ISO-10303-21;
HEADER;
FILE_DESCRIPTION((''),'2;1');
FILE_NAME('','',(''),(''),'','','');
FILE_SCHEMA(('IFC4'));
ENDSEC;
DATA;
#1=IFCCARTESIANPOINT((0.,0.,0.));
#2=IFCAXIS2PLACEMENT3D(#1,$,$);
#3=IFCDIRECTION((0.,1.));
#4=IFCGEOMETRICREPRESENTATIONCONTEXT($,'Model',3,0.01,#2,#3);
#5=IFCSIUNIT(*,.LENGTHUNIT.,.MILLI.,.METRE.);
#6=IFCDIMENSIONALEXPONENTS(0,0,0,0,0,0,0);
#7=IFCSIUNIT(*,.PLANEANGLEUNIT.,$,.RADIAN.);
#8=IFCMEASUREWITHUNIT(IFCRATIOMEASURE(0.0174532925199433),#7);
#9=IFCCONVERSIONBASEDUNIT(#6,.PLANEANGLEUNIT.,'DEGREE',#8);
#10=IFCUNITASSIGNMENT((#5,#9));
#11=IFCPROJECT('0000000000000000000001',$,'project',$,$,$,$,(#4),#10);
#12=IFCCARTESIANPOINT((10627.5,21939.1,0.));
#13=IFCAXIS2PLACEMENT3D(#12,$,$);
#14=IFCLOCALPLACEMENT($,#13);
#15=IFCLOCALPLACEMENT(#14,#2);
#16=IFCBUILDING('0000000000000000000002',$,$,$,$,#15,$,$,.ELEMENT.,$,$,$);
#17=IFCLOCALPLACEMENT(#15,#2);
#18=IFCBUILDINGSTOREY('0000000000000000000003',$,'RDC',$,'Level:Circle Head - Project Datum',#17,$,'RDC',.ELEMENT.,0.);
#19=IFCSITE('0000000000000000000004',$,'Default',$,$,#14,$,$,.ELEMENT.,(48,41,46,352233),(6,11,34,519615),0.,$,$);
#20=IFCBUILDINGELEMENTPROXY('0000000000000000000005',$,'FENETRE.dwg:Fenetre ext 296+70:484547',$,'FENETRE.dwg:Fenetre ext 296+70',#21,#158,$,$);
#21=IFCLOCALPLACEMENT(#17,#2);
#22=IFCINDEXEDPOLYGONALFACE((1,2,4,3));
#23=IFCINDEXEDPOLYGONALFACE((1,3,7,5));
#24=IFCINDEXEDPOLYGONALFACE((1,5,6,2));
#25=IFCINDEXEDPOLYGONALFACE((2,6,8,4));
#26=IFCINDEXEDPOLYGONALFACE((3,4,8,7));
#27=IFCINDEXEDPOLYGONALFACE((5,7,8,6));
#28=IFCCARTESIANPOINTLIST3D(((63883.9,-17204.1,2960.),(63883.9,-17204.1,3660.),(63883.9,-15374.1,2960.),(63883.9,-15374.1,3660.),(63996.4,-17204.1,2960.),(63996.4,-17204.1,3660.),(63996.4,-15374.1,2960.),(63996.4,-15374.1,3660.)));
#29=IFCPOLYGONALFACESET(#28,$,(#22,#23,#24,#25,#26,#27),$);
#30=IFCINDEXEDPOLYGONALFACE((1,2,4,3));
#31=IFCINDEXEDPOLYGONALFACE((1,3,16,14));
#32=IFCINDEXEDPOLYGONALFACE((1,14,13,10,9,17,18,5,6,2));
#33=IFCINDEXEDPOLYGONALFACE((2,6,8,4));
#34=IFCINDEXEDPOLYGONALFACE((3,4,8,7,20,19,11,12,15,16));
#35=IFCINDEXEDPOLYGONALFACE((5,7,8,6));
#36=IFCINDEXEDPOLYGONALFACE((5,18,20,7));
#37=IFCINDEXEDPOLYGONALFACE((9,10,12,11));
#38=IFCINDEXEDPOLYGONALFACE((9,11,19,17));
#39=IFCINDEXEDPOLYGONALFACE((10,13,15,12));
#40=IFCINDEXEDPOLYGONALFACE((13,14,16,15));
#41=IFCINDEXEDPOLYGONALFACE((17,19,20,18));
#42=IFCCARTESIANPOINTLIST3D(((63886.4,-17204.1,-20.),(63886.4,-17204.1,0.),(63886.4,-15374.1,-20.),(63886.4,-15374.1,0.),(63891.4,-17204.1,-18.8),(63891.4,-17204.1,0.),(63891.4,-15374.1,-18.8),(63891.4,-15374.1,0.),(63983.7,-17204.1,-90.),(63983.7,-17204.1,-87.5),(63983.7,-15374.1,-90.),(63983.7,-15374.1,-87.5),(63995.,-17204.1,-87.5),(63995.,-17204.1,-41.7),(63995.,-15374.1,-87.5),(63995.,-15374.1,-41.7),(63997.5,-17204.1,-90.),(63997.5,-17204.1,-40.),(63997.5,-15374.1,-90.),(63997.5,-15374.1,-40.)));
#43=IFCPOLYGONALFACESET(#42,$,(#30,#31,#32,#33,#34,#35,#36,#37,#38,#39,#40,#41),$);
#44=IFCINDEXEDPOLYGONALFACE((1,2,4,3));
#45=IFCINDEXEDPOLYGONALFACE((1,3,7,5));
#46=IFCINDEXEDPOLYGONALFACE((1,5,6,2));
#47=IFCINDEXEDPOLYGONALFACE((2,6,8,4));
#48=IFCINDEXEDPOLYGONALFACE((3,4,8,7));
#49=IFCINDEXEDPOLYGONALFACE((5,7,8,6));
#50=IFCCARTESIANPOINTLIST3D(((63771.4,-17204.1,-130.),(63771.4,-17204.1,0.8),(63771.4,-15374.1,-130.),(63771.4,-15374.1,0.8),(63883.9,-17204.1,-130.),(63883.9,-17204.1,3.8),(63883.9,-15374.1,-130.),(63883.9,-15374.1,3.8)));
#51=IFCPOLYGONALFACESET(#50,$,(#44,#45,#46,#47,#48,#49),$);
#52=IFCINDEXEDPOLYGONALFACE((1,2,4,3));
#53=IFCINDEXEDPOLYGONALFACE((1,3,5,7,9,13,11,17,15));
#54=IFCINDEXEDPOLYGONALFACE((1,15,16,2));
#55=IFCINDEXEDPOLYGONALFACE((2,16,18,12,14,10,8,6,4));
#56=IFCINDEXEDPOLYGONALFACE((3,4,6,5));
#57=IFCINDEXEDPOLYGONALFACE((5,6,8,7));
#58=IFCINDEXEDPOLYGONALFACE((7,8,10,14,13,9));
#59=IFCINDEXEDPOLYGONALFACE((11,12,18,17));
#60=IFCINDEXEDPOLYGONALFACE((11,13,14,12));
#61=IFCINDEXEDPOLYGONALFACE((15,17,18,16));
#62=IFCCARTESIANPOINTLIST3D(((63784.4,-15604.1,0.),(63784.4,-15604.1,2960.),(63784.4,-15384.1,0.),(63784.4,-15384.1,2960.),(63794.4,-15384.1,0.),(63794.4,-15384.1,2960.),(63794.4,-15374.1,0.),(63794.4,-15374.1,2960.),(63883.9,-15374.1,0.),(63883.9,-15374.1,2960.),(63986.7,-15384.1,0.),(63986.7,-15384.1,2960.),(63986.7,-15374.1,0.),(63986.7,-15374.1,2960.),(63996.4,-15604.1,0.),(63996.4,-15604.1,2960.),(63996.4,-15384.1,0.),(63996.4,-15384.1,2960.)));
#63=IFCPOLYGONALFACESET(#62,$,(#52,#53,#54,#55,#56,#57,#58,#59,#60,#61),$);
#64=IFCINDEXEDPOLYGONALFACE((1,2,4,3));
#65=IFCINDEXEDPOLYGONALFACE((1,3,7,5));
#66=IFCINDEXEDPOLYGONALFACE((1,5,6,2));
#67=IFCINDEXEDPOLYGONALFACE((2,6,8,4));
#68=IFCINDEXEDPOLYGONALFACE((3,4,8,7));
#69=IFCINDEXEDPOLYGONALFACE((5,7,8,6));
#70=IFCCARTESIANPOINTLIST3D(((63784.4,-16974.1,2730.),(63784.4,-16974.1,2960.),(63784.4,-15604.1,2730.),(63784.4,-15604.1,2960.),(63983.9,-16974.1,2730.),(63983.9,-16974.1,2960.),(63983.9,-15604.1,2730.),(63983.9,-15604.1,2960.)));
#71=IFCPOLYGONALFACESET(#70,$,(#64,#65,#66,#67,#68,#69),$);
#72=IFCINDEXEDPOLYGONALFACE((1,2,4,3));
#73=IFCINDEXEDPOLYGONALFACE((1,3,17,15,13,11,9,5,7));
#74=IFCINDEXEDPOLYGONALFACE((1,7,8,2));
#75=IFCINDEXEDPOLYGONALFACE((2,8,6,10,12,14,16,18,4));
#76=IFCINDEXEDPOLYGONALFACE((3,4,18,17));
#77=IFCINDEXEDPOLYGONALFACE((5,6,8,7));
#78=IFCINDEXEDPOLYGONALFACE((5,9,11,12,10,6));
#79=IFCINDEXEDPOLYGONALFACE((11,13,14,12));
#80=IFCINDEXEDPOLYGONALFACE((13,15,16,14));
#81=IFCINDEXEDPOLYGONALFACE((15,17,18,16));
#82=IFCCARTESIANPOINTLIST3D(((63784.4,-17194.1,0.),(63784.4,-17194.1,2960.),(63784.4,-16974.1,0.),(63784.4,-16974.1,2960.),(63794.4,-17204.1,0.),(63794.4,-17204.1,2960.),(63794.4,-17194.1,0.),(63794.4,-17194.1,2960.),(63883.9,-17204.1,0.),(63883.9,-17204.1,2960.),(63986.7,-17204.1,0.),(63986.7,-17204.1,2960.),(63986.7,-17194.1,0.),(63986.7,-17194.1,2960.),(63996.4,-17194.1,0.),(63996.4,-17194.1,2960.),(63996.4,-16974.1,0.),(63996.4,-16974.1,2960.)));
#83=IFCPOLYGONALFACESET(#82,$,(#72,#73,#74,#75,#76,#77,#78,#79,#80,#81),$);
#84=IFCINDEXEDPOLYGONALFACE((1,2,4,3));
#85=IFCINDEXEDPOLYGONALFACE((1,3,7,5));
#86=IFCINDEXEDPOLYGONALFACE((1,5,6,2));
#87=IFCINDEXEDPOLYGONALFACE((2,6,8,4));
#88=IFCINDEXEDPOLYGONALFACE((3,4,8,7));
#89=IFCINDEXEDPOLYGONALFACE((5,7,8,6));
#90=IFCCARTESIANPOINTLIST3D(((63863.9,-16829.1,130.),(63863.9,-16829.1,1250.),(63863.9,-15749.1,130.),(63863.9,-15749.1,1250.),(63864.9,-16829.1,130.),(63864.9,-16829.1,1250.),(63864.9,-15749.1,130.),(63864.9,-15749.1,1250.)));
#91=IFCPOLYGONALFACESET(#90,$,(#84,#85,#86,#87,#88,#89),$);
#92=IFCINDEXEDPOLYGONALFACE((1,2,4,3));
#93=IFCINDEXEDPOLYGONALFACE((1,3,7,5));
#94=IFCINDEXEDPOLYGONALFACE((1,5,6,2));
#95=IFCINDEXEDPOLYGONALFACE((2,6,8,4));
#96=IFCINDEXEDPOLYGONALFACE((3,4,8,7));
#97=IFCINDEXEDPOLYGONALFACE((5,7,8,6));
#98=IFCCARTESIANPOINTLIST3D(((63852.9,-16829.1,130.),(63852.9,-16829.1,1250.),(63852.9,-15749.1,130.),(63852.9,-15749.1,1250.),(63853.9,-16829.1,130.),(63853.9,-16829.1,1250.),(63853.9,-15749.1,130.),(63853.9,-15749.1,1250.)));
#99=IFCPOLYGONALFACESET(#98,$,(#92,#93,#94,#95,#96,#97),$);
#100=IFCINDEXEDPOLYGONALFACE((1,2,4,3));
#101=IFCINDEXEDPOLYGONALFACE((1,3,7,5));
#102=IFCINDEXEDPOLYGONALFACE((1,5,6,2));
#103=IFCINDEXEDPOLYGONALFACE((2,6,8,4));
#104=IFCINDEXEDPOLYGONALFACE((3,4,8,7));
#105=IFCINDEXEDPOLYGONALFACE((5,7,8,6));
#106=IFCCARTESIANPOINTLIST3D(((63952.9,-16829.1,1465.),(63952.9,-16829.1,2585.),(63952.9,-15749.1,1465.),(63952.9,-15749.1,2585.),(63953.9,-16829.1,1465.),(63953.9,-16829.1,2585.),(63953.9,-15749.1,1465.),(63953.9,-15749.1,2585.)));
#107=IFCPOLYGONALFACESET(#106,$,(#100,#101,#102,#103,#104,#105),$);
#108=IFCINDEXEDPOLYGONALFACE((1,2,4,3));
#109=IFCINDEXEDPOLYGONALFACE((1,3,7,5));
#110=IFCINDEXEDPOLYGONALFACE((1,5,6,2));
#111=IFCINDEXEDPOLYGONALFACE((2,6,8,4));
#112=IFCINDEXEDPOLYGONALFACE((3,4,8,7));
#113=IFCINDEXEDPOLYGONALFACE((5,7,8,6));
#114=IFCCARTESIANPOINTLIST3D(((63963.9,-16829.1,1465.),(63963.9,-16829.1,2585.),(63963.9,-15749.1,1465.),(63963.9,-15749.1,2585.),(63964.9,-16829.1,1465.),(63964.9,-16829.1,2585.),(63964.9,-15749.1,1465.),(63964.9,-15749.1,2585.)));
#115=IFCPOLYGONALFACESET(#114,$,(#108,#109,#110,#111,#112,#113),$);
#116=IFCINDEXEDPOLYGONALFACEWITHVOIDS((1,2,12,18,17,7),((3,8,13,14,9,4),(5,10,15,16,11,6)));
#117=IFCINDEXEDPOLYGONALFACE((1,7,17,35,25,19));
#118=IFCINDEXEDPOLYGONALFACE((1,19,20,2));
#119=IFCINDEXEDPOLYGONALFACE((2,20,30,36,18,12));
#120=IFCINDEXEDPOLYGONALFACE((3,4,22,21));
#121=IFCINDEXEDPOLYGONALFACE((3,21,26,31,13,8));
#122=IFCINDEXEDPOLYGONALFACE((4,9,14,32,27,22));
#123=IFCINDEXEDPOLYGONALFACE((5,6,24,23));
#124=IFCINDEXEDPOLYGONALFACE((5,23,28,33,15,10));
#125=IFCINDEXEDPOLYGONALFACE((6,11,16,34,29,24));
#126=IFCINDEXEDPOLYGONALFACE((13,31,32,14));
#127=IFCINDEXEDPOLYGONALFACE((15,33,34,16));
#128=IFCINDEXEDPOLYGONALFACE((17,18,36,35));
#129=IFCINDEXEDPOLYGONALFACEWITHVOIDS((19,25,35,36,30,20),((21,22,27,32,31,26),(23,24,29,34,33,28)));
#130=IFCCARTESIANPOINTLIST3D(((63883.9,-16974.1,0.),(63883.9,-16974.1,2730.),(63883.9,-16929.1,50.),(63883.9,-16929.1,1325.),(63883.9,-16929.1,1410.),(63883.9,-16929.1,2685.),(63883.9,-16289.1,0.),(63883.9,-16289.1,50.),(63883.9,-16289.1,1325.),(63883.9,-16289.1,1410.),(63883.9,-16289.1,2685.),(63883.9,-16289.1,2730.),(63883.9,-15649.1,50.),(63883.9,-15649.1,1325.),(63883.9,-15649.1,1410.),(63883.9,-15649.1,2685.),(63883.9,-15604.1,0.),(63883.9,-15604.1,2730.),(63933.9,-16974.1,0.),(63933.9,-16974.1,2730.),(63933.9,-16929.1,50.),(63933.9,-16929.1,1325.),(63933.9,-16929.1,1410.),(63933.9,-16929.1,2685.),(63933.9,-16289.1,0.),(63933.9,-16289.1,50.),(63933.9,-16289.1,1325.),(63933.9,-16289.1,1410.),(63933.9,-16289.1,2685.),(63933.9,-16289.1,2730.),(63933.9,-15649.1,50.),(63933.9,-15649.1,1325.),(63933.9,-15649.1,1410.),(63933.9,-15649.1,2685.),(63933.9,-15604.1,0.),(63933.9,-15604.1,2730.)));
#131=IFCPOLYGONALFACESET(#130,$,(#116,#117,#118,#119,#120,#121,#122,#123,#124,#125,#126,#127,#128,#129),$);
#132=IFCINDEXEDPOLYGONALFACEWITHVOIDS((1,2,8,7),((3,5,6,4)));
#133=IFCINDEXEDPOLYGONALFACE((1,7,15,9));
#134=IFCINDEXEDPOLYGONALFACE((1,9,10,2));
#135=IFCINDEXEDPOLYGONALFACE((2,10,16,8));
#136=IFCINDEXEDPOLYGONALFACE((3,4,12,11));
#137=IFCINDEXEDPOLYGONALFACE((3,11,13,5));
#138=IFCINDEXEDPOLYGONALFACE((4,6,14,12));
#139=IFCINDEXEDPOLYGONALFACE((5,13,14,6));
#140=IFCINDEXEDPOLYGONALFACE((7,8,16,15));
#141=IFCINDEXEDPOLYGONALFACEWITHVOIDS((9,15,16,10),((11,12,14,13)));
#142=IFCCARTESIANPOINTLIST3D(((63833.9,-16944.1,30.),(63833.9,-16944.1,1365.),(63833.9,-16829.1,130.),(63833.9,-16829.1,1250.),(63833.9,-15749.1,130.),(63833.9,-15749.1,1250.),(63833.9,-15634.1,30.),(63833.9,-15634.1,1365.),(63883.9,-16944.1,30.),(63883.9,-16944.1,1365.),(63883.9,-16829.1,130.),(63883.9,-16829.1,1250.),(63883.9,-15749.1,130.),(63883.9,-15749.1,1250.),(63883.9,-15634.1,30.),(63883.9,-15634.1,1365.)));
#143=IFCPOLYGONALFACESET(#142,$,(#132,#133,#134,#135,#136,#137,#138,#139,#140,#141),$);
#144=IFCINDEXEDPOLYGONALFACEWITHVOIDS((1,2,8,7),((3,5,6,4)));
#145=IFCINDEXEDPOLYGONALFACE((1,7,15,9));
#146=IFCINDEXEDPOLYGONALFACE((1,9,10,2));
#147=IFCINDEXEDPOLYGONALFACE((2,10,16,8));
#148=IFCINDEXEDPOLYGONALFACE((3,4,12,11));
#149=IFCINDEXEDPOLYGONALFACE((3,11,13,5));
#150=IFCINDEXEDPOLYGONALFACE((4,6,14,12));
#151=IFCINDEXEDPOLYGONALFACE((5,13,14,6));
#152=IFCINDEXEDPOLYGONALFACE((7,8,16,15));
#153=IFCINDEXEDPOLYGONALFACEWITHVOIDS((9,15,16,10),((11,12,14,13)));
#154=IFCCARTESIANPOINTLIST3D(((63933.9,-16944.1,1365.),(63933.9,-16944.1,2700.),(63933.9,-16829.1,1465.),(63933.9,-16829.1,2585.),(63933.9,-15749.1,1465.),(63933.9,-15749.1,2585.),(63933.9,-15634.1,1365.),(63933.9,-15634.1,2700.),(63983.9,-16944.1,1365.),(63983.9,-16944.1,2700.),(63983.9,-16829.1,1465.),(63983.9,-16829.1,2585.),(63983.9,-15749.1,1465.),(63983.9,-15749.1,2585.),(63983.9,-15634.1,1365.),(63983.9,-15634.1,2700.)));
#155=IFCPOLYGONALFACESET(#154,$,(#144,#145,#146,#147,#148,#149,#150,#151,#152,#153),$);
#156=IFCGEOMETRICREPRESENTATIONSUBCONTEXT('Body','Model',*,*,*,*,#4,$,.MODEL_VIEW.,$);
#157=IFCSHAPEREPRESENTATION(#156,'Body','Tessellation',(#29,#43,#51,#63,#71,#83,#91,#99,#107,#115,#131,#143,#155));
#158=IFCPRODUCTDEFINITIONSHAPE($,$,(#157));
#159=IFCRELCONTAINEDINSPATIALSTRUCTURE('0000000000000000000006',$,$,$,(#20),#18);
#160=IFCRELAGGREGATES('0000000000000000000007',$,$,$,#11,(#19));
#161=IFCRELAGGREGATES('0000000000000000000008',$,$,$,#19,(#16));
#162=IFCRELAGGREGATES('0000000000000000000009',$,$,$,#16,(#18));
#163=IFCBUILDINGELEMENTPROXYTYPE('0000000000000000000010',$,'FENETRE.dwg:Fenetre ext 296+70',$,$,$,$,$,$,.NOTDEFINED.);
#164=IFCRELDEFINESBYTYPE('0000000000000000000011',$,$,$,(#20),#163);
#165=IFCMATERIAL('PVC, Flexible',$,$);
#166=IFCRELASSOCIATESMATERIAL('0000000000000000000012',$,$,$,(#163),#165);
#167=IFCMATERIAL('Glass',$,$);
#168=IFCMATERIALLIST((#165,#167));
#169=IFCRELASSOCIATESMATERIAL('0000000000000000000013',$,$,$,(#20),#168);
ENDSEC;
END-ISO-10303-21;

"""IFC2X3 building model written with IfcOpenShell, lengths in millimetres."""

from ifc_helpers import new_model, entity, si_unit, converted_unit, direction, frame, frame_2d, origin, origin_2d_with_axis, place, context, subcontext, project, spatial, polyline, rectangle, outline, extrude, source, transform, mapped, material, material_list, type_object, type_shapes, element, save


model = new_model("IFC2X3")

# Units and contexts
model_context = context("Model", 3, precision=0.01, world=origin(), true_north=direction((0.0, 1.0)))
body_context = subcontext(model_context, "Body", "Model", "MODEL_VIEW")
ifc_project = project(units=[si_unit("LENGTHUNIT", "METRE", prefix="MILLI"), converted_unit("PLANEANGLEUNIT", "DEGREE", entity("IfcRatioMeasure", 0.0174532925199433), si_unit("PLANEANGLEUNIT", "RADIAN"), dimensions=[0, 0, 0, 0, 0, 0, 0])], contexts=[model_context])

# Site, building, storey
site_placement = place(None, frame((10627.5, 21939.1, 0.0)))
site = spatial("IfcSite", under=ifc_project, at=site_placement, Name="Default", CompositionType="ELEMENT", RefLatitude=(48, 41, 46, 352233), RefLongitude=(6, 11, 34, 519615), RefElevation=0.0)
building_placement = place(site_placement, origin())
building = spatial("IfcBuilding", under=site, at=building_placement, CompositionType="ELEMENT")
storey_placement = place(building_placement, origin())
storey = spatial("IfcBuildingStorey", under=building, at=storey_placement, Name="RDC", ObjectType="Level:Circle Head - Project Datum", LongName="RDC", CompositionType="ELEMENT", Elevation=0.0)

# Building element proxy
ifc_material_1 = material(Name="PVC, Flexible")
ifc_material_2 = material(Name="Glass")
building_element_proxy_type_1 = type_object("IfcBuildingElementProxyType", Name="FENETRE.dwg:Fenetre ext 296+70", PredefinedType="NOTDEFINED", material=ifc_material_1)
shared_shape_1 = source(origin(), body_context, "Body", "SweptSolid", [
    extrude(rectangle(XDim=112.5, YDim=1830.0, at=origin_2d_with_axis()), frame((-10.4, -56.3, 2960.0), z_axis=(0.0, 0.0, 1.0), x_axis=(0.0, 1.0, 0.0)), (0.0, 0.0, 1.0), 700.0),
    extrude(outline(polyline([(27.5, -64.4), (47.5, -64.4), (47.5, -59.4), (28.8, -59.4), (7.5, 46.7), (-42.5, 46.7), (-42.5, 32.9), (-40.0, 32.9), (-40.0, 44.2), (5.8, 44.2), (27.5, -64.4)])), frame((-925.4, -66.9, -47.5), z_axis=(1.0, 0.0, 0.0), x_axis=(0.0, 0.0, 1.0)), (0.0, 0.0, 1.0), 1830.0),
    extrude(outline(polyline([(-54.5, -66.1), (58.0, -66.1), (54.5, 67.6), (-58.0, 64.6), (-54.5, -66.1)])), frame((-925.4, 56.3, -63.8), z_axis=(1.0, 0.0, 0.0), x_axis=(0.0, -0.999645, 0.02665)), (0.0, 0.0, 1.0), 1830.0),
    extrude(outline(polyline([(-97.0, -55.6), (5.9, -55.6), (95.4, -55.6), (95.4, -45.6), (105.4, -45.6), (105.4, 174.4), (-106.6, 174.4), (-106.6, -45.6), (-97.0, -45.6), (-97.0, -55.6)])), frame((849.0, -5.9, 0.0), z_axis=(0.0, 0.0, 1.0), x_axis=(0.0, 1.0, 0.0)), (0.0, 0.0, 1.0), 2960.0),
    extrude(rectangle(XDim=1370.0, YDim=199.5, at=origin_2d_with_axis()), frame((-10.4, -0.3, 2730.0), z_axis=(0.0, 0.0, 1.0), x_axis=(-1.0, 0.0, 0.0)), (0.0, 0.0, 1.0), 230.0),
    extrude(outline(polyline([(-55.6, 97.0), (-55.6, -5.9), (-55.6, -95.4), (-45.6, -95.4), (-45.6, -105.4), (174.4, -105.4), (174.4, 106.6), (-45.6, 106.6), (-45.6, 97.0), (-55.6, 97.0)])), frame((-869.9, -5.9, 0.0), z_axis=(0.0, 0.0, -1.0), x_axis=(1.0, 0.0, 0.0)), (0.0, 0.0, -1.0), 2960.0),
    extrude(rectangle(XDim=1080.0, YDim=1.0, at=origin_2d_with_axis()), frame((-10.4, 19.5, 130.0), z_axis=(0.0, 0.0, 1.0), x_axis=(-1.0, 0.0, 0.0)), (0.0, 0.0, 1.0), 1120.0),
    extrude(rectangle(XDim=1080.0, YDim=1.0, at=origin_2d_with_axis()), frame((-10.4, 30.5, 130.0), z_axis=(0.0, 0.0, 1.0), x_axis=(-1.0, 0.0, 0.0)), (0.0, 0.0, 1.0), 1120.0),
    extrude(rectangle(XDim=1080.0, YDim=1.0, at=frame_2d((0.0, 0.0), x_axis=(1.0, 0.0))), frame((-10.4, -69.5, 1465.0), z_axis=(0.0, 0.0, 1.0), x_axis=(-1.0, 0.0, 0.0)), (0.0, 0.0, 1.0), 1120.0),
    extrude(rectangle(XDim=1080.0, YDim=1.0, at=frame_2d((0.0, 0.0), x_axis=(1.0, 0.0))), frame((-10.4, -80.5, 1465.0), z_axis=(0.0, 0.0, 1.0), x_axis=(-1.0, 0.0, 0.0)), (0.0, 0.0, 1.0), 1120.0),
    extrude(outline(polyline([(-685.0, -1365.0), (0.0, -1365.0), (685.0, -1365.0), (685.0, 1365.0), (0.0, 1365.0), (-685.0, 1365.0), (-685.0, -1365.0)]), holes=[polyline([(-640.0, -1320.0), (-640.0, -45.0), (0.0, -45.0), (640.0, -45.0), (640.0, -1320.0), (0.0, -1320.0), (-640.0, -1320.0)]), polyline([(-640.0, 40.0), (-640.0, 1315.0), (0.0, 1315.0), (640.0, 1315.0), (640.0, 40.0), (0.0, 40.0), (-640.0, 40.0)])]), frame((-10.4, -50.0, 1365.0), z_axis=(0.0, 1.0, 0.0), x_axis=(1.0, 0.0, 0.0)), (0.0, 0.0, 1.0), 50.0),
    extrude(outline(polyline([(-655.0, -667.5), (655.0, -667.5), (655.0, 667.5), (-655.0, 667.5), (-655.0, -667.5)]), holes=[polyline([(-540.0, 552.5), (540.0, 552.5), (540.0, -567.5), (-540.0, -567.5), (-540.0, 552.5)])]), frame((-10.4, 0.0, 697.5), z_axis=(0.0, 1.0, 0.0), x_axis=(-1.0, 0.0, 0.0)), (0.0, 0.0, 1.0), 50.0),
    extrude(outline(polyline([(-655.0, -667.5), (655.0, -667.5), (655.0, 667.5), (-655.0, 667.5), (-655.0, -667.5)]), holes=[polyline([(-540.0, 552.5), (540.0, 552.5), (540.0, -567.5), (-540.0, -567.5), (-540.0, 552.5)])]), frame((-10.4, -100.0, 2032.5), z_axis=(0.0, 1.0, 0.0), x_axis=(-1.0, 0.0, 0.0)), (0.0, 0.0, 1.0), 50.0),
])
type_shapes(building_element_proxy_type_1, [shared_shape_1])
ifc_material_list_1 = material_list([ifc_material_1, ifc_material_2])
proxy_1_placement = place(storey_placement, frame((63883.9, -16278.7, 0.0), z_axis=(0.0, 0.0, 1.0), x_axis=(0.0, 1.0, 0.0)))
element("IfcBuildingElementProxy", 1, at=proxy_1_placement, inside=storey, type_object=building_element_proxy_type_1, material=ifc_material_list_1, Name="FENETRE.dwg:Fenetre ext 296+70:484547", ObjectType="FENETRE.dwg:Fenetre ext 296+70", context=body_context, shape_type="MappedRepresentation", body=[
    mapped(shared_shape_1, transform((0.0, 0.0, 0.0), scale=1.0)),
])

save(model, "model.ifc")
